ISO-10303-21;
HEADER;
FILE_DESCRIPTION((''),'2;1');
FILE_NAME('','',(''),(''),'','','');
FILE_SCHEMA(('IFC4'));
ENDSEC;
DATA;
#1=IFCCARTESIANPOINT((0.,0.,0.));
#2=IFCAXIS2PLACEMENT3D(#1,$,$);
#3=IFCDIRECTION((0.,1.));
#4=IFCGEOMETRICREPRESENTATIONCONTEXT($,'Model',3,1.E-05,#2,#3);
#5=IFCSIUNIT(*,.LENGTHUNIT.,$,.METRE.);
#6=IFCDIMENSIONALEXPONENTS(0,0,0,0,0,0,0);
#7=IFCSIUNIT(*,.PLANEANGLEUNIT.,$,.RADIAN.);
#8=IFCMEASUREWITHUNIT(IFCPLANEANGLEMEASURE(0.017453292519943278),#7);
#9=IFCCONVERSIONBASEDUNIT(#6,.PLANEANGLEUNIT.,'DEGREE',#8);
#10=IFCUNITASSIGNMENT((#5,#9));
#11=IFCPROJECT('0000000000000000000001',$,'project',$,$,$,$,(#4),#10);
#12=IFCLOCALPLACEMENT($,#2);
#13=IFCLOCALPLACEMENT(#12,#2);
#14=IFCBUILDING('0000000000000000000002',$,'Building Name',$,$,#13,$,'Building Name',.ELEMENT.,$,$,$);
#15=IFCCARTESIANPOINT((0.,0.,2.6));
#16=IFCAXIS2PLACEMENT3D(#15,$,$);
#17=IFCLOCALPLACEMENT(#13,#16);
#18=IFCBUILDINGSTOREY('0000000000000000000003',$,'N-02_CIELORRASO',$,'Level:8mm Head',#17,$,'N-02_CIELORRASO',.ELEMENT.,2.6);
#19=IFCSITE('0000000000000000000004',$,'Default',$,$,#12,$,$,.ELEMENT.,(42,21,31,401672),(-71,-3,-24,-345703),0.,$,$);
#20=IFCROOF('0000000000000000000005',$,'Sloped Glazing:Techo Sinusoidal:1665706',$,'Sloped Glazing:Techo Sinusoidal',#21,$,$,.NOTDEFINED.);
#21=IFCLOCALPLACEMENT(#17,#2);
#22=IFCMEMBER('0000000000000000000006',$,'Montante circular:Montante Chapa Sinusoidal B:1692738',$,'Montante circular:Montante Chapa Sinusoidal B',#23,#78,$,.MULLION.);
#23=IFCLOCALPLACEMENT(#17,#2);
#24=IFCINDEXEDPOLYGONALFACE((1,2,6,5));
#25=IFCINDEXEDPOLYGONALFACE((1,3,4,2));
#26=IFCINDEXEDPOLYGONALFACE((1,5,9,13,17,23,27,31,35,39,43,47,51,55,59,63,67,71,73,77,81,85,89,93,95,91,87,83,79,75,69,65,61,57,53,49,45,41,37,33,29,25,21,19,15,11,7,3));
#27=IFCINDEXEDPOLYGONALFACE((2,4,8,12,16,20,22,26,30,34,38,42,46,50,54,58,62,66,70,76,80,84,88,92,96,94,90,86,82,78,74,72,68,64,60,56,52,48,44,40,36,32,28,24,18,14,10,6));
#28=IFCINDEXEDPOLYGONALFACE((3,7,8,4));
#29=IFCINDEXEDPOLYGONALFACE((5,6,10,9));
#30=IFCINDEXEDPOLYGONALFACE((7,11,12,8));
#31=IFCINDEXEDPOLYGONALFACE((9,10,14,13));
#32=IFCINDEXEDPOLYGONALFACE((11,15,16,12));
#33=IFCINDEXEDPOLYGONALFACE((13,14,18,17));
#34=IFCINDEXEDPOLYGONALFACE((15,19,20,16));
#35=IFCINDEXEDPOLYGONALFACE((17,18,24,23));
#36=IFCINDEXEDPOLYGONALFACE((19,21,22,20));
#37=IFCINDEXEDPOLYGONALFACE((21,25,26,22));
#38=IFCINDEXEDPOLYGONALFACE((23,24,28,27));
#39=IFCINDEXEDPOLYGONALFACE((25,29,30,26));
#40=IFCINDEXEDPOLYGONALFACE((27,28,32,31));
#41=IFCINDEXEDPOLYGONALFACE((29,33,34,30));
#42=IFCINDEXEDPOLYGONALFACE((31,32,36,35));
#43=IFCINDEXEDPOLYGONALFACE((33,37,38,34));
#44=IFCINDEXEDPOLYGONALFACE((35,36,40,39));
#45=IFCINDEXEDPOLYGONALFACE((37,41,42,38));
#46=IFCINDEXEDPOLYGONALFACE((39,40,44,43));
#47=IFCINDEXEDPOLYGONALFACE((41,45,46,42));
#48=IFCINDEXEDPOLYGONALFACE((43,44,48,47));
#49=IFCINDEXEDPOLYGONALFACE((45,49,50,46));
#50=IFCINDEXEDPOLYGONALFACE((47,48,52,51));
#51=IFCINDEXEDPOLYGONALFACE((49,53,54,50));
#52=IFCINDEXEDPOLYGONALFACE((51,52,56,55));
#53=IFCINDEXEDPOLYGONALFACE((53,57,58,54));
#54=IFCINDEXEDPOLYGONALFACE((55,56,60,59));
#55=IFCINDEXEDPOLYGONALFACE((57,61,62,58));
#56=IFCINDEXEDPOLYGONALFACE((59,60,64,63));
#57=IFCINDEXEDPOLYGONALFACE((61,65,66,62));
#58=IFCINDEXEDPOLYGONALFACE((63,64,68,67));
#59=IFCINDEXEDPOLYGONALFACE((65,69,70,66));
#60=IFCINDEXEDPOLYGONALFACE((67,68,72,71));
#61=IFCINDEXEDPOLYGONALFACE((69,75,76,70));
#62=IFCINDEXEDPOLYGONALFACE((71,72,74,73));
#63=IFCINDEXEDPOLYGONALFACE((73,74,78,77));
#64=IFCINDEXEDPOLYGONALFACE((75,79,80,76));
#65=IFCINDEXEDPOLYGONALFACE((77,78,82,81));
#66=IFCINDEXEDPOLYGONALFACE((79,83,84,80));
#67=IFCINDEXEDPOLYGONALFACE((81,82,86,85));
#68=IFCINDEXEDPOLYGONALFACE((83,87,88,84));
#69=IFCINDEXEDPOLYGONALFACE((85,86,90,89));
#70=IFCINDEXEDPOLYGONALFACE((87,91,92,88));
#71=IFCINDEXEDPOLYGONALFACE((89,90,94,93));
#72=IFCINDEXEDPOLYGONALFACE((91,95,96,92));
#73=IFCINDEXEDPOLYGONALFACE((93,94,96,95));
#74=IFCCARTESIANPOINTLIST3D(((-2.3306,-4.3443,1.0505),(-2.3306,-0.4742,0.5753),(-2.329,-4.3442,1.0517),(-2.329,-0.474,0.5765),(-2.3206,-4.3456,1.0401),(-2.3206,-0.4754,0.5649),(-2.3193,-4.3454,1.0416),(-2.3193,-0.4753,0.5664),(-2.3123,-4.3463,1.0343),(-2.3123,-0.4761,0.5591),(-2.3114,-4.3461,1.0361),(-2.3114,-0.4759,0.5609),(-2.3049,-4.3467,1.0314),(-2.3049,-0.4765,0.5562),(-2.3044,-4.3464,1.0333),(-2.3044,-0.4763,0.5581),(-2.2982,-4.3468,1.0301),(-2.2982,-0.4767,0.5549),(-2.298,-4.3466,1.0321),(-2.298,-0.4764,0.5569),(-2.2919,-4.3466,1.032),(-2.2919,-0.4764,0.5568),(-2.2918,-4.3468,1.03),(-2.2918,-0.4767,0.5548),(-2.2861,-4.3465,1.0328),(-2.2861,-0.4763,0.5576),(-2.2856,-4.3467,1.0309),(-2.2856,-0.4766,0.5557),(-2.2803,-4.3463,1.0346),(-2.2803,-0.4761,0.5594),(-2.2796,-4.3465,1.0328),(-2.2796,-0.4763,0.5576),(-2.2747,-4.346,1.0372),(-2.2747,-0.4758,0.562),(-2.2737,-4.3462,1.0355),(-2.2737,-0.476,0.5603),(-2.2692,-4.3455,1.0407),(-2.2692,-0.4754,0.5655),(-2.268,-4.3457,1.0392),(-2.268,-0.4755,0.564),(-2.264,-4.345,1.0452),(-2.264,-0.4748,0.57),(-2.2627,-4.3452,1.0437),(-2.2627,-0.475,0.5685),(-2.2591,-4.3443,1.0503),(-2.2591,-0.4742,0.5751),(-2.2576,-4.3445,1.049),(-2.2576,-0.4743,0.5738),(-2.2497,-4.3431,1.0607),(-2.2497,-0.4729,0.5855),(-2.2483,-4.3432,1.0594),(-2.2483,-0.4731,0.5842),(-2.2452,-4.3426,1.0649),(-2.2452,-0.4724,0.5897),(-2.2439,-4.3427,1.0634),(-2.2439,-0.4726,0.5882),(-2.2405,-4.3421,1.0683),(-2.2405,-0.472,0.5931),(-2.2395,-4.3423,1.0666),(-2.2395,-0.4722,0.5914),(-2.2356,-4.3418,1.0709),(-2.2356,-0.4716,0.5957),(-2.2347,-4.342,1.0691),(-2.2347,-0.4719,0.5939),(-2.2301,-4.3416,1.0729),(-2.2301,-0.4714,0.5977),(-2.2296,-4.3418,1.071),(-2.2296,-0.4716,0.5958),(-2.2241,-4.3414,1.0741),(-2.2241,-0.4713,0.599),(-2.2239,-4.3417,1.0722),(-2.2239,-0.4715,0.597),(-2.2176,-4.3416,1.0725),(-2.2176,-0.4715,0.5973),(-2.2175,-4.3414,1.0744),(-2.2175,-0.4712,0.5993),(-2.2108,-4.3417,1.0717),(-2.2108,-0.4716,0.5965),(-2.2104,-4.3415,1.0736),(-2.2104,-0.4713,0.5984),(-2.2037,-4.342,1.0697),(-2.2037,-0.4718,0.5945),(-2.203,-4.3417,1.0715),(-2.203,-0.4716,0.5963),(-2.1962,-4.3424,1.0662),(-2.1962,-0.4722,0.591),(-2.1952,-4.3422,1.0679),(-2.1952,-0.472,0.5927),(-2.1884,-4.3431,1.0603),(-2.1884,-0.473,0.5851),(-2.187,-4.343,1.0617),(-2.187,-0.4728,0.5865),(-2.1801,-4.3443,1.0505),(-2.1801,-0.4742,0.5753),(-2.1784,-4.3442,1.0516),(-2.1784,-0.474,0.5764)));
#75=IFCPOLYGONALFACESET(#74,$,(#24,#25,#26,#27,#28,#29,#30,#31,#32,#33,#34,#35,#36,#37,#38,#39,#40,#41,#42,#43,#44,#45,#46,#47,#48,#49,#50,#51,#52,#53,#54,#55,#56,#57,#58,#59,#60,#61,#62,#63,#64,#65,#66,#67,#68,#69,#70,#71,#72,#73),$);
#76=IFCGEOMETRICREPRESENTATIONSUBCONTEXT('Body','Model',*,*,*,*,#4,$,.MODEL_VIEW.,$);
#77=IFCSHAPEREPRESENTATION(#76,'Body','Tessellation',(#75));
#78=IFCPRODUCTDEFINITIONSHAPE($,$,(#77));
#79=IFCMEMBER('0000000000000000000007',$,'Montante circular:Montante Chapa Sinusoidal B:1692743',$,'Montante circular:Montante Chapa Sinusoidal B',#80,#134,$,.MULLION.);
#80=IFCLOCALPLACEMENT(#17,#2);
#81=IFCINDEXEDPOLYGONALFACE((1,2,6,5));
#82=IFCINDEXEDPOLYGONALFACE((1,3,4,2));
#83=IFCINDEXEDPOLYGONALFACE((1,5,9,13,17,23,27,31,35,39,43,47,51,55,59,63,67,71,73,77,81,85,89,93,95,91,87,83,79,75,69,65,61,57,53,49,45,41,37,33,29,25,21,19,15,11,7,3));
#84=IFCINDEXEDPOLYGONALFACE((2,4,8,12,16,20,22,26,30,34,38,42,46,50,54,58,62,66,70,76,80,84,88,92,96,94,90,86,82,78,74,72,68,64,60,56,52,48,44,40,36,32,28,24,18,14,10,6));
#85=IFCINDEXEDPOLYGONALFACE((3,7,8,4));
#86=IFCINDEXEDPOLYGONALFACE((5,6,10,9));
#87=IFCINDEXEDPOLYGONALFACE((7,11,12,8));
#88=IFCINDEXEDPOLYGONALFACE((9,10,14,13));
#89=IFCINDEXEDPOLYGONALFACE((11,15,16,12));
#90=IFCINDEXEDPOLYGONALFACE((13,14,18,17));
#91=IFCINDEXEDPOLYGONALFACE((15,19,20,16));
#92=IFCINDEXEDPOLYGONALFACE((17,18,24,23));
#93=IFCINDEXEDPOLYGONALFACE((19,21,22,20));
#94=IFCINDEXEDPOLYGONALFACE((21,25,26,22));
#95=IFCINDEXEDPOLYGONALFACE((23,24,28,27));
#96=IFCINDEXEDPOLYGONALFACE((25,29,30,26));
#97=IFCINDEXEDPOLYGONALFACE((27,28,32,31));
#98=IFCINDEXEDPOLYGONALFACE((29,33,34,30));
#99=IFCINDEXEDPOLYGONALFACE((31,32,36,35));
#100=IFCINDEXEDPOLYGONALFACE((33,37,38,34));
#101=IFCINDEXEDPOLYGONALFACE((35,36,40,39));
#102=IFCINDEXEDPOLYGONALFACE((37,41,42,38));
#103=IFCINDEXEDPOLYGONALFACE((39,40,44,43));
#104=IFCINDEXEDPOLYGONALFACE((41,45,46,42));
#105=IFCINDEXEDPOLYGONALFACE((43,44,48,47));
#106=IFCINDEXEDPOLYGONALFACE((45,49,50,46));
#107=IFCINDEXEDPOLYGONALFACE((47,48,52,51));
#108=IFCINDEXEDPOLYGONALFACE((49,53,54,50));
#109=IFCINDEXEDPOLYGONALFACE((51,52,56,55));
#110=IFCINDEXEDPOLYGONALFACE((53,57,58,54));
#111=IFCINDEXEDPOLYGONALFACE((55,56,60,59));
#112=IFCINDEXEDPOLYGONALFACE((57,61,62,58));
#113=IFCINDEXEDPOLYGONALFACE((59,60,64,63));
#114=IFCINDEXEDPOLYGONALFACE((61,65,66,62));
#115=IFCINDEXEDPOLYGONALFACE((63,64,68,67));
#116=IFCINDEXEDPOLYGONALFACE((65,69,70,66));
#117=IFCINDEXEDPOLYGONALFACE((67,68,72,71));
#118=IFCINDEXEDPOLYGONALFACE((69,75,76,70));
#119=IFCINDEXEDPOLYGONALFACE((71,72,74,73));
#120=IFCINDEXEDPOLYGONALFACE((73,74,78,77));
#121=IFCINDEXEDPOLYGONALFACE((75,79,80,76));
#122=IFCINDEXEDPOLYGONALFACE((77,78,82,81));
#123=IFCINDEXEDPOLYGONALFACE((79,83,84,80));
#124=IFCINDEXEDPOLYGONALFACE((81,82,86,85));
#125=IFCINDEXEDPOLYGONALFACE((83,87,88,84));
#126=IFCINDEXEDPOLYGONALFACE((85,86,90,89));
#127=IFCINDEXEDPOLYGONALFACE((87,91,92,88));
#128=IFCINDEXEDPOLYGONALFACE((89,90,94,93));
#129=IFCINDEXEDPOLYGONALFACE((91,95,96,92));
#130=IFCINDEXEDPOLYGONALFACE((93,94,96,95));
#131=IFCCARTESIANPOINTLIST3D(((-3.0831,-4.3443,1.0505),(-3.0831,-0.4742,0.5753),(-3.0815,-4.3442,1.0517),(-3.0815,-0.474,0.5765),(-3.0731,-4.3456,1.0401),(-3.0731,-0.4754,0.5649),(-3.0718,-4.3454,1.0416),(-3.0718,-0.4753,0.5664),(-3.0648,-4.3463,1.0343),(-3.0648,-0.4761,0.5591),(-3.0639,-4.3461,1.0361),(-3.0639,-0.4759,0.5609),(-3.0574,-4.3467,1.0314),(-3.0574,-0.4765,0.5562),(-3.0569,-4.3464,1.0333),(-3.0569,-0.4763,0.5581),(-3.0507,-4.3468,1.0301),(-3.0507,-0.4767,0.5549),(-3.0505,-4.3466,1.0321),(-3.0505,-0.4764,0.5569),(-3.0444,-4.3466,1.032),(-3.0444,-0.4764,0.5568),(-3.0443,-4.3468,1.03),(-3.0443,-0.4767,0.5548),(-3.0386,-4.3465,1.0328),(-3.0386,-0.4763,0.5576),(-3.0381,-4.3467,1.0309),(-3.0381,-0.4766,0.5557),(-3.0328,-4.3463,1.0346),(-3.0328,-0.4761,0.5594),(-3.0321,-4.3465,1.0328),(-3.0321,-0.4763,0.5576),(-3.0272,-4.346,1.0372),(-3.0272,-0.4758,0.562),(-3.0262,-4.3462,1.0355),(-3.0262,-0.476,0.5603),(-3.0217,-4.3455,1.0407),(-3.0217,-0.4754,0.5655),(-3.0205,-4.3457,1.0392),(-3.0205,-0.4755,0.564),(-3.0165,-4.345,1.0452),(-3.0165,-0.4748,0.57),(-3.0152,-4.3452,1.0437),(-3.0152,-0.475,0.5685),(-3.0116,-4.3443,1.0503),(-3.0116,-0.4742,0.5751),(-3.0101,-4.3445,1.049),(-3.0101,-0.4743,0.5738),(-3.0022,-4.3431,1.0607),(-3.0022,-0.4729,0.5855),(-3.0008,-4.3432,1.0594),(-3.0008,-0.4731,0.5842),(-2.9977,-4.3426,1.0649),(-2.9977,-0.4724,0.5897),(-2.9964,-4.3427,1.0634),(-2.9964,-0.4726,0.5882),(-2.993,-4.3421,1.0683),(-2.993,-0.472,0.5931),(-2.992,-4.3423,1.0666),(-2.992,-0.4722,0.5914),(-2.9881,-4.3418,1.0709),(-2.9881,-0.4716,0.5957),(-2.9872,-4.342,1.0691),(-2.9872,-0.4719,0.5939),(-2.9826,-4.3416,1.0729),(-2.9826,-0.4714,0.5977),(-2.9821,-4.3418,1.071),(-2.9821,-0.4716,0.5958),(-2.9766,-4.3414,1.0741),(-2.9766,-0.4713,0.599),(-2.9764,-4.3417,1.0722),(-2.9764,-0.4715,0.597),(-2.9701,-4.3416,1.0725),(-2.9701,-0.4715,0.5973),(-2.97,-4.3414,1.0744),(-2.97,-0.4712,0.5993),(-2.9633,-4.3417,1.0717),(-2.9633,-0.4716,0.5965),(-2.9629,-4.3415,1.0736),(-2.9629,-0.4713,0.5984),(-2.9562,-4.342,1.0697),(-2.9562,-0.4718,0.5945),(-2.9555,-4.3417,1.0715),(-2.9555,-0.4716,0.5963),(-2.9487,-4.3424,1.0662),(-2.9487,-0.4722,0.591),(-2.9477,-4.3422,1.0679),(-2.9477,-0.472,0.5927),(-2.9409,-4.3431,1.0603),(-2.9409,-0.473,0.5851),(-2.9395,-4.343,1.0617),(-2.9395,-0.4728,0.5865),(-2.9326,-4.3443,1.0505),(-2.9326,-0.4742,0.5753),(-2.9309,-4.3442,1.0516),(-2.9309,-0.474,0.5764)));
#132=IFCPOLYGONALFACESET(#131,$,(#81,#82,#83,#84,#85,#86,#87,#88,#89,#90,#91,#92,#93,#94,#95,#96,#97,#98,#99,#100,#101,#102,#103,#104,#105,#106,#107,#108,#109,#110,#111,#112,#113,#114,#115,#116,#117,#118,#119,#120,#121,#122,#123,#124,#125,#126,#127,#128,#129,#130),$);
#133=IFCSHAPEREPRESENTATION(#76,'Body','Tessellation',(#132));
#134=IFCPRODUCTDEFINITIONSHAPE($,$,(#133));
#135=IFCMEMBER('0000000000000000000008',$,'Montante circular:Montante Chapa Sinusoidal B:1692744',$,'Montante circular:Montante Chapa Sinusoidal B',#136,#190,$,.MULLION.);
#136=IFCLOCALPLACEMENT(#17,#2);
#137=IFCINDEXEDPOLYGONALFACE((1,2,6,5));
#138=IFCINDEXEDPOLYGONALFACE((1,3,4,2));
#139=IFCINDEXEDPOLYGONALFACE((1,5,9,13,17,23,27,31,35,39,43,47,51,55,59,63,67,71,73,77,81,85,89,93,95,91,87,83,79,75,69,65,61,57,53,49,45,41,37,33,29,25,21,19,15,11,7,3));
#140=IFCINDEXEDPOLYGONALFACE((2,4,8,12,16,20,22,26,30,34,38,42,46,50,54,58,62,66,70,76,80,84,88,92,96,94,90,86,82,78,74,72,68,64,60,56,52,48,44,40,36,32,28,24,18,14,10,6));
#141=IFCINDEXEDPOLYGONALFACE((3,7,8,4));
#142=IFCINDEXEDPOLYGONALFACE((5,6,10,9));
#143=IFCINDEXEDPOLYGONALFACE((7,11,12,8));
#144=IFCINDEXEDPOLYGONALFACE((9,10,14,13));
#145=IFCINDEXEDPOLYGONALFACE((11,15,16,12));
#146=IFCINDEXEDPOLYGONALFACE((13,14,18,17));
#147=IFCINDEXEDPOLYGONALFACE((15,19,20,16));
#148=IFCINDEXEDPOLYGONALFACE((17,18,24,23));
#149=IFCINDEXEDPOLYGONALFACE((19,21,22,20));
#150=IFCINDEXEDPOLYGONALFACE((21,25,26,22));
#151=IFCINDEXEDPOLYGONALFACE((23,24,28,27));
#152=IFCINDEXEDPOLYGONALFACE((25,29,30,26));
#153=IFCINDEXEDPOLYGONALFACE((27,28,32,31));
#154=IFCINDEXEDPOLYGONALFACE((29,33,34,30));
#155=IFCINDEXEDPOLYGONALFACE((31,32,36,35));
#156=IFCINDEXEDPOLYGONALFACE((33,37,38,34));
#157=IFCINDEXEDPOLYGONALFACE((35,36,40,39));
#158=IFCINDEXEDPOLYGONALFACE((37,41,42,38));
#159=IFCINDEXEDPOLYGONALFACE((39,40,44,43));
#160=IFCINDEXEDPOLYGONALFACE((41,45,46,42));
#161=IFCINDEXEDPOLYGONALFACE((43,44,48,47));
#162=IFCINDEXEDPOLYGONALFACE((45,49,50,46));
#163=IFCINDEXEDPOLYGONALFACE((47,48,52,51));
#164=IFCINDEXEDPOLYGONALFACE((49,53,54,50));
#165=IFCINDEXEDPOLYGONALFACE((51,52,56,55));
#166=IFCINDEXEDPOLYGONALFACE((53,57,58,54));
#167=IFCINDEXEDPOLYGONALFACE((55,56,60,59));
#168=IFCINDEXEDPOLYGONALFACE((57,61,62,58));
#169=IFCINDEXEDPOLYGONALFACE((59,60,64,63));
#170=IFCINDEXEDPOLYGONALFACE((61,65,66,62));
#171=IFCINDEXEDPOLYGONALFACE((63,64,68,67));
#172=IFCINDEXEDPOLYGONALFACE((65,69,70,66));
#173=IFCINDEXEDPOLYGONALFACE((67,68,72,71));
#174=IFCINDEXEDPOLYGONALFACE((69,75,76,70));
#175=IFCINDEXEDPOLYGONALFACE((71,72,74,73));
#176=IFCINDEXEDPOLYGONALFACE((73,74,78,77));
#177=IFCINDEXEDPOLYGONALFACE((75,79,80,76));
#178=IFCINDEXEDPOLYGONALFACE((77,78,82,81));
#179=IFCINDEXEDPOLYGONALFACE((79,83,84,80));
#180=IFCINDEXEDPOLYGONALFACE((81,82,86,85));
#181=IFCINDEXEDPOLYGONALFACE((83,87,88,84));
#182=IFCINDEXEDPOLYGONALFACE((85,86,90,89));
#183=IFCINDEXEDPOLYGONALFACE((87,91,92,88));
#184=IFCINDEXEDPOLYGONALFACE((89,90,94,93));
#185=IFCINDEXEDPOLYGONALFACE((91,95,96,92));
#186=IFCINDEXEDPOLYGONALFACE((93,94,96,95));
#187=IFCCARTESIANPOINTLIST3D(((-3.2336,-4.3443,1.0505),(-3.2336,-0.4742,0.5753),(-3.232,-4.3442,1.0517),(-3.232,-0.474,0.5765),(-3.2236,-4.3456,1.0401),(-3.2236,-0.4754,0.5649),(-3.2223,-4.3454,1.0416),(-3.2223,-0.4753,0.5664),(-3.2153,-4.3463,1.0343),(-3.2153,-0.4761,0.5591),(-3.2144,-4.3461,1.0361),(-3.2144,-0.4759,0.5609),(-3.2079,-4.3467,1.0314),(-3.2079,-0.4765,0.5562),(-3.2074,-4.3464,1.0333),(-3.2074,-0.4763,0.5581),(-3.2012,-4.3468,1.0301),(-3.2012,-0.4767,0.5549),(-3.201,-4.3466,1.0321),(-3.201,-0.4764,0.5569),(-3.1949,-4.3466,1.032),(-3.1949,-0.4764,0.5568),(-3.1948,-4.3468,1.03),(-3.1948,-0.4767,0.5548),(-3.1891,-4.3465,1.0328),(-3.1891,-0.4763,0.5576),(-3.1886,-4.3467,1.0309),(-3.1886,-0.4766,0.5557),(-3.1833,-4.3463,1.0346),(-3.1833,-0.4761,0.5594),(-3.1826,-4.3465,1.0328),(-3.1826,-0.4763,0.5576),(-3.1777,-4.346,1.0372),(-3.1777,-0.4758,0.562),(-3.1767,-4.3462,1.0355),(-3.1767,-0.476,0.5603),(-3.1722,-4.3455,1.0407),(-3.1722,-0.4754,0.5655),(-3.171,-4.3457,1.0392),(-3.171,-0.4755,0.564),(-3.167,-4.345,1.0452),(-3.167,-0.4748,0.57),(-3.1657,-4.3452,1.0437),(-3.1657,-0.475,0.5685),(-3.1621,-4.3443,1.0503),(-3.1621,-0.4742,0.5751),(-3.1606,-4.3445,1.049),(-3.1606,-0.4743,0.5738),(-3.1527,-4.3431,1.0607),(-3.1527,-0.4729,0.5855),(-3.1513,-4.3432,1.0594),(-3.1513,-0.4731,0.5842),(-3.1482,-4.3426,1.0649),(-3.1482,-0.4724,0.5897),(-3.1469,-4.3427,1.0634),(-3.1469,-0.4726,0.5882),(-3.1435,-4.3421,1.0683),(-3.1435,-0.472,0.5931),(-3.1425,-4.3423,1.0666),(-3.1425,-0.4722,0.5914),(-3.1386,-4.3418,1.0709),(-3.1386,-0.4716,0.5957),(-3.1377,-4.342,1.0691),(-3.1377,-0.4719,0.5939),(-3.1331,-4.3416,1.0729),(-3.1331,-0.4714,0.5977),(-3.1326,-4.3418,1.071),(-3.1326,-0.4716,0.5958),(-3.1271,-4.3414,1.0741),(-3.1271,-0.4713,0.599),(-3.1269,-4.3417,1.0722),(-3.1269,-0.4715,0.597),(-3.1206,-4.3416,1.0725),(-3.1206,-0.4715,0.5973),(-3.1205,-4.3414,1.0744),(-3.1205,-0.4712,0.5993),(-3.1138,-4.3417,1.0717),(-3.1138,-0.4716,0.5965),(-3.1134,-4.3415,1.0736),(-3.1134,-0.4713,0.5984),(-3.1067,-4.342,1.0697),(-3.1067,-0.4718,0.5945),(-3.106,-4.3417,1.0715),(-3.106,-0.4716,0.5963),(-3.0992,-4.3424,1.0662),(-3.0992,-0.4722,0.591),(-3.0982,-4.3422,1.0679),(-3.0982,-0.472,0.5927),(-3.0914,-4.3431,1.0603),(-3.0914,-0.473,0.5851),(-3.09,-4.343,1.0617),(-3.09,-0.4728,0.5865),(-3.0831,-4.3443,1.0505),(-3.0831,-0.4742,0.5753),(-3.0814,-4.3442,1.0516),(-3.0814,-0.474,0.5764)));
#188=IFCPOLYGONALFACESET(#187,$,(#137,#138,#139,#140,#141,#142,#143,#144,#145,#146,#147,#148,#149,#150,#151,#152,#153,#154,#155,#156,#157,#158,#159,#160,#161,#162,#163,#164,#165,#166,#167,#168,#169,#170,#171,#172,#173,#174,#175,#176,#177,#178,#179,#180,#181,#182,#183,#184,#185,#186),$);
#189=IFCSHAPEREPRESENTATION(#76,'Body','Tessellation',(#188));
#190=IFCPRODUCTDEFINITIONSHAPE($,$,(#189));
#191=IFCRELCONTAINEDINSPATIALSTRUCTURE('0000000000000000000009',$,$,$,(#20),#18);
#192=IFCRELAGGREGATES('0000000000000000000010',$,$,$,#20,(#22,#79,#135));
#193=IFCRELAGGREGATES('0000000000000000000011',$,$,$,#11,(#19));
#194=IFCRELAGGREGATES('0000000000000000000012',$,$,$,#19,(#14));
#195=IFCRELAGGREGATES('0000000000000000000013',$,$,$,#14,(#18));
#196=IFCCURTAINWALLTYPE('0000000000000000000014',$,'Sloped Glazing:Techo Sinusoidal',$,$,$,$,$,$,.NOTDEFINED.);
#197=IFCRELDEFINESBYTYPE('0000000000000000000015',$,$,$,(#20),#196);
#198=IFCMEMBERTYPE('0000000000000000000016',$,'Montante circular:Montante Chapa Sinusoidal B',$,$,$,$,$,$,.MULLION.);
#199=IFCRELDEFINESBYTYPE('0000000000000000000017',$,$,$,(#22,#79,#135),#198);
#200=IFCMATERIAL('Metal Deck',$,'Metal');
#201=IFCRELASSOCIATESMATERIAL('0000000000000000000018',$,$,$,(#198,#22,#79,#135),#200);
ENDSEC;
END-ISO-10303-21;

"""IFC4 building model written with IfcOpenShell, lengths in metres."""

from ifc_helpers import new_model, entity, si_unit, converted_unit, direction, frame, origin, place, context, subcontext, project, spatial, indexed_curve, outline, extrude, source, transform, mapped, material, type_object, type_shapes, element, aggregate, save


model = new_model("IFC4")

# Units and contexts
model_context = context("Model", 3, precision=1e-05, world=origin(), true_north=direction((0.0, 1.0)))
body_context = subcontext(model_context, "Body", "Model", "MODEL_VIEW")
ifc_project = project(units=[si_unit("LENGTHUNIT", "METRE"), converted_unit("PLANEANGLEUNIT", "DEGREE", entity("IfcPlaneAngleMeasure", 0.017453292519943278), si_unit("PLANEANGLEUNIT", "RADIAN"), dimensions=[0, 0, 0, 0, 0, 0, 0])], contexts=[model_context])

# Site, building, storey
site_placement = place(None, origin())
site = spatial("IfcSite", under=ifc_project, at=site_placement, Name="Default", CompositionType="ELEMENT", RefLatitude=(42, 21, 31, 401672), RefLongitude=(-71, -3, -24, -345703), RefElevation=0.0)
building_placement = place(site_placement, origin())
building = spatial("IfcBuilding", under=site, at=building_placement, Name="Building Name", LongName="Building Name", CompositionType="ELEMENT")
storey_placement = place(building_placement, frame((0.0, 0.0, 2.6)))
storey = spatial("IfcBuildingStorey", under=building, at=storey_placement, Name="N-02_CIELORRASO", ObjectType="Level:8mm Head", LongName="N-02_CIELORRASO", CompositionType="ELEMENT", Elevation=2.6)

# Roof, members
curtain_wall_type = type_object("IfcCurtainWallType", Name="Sloped Glazing:Techo Sinusoidal", PredefinedType="NOTDEFINED")
ifc_material = material(Name="Metal Deck", Category="Metal")
roof_1_placement = place(storey_placement, frame((0.0, 0.0, -2.6)))
roof_1 = element("IfcRoof", 1, at=roof_1_placement, inside=storey, type_object=curtain_wall_type, Name="Sloped Glazing:Techo Sinusoidal:1665706", ObjectType="Sloped Glazing:Techo Sinusoidal", PredefinedType="NOTDEFINED")
member_type_1 = type_object("IfcMemberType", Name="Montante circular:Montante Chapa Sinusoidal B", PredefinedType="MULLION", material=ifc_material)
shared_shape_1 = source(origin(), body_context, "Body", "SweptSolid", [
    extrude(outline(indexed_curve([(0.0595, -0.0443), (0.0615, -0.0443), (0.0603, -0.031), (0.0572, -0.0213), (0.053, -0.0138), (0.0481, -0.0078), (0.0427, -0.003), (0.0372, 0.0005), (0.0315, 0.0029), (0.0259, 0.0044), (0.0203, 0.0051), (0.0146, 0.005), (0.0084, 0.0041), (-0.0053, 0.0009), (-0.0123, -0.0005), (-0.0191, -0.0012), (-0.0256, -0.001), (-0.0317, 0.0001), (-0.0375, 0.0019), (-0.0428, 0.0046), (-0.0477, 0.0081), (-0.0522, 0.0128), (-0.0563, 0.0191), (-0.0597, 0.0282), (-0.0617, 0.0421), (-0.0637, 0.042), (-0.0616, 0.0277), (-0.0581, 0.0182), (-0.0537, 0.0116), (-0.049, 0.0066), (-0.0438, 0.0028), (-0.0382, 0.0001), (-0.0322, -0.0019), (-0.0258, -0.003), (-0.019, -0.0032), (-0.012, -0.0025), (-0.0048, -0.0011), (0.0088, 0.0021), (0.0147, 0.003), (0.0202, 0.0031), (0.0255, 0.0024), (0.0309, 0.001), (0.0362, -0.0013), (0.0415, -0.0046), (0.0466, -0.0092), (0.0513, -0.0149), (0.0554, -0.0221), (0.0584, -0.0314), (0.0595, -0.0443)], self_intersect=False)), frame((-0.007, 0.0228, -3.8992), z_axis=(0.0, 0.0, 1.0), x_axis=(-0.819152, -0.573576, 0.0)), (0.0, 0.0, 1.0), 3.8992),
])
type_shapes(member_type_1, [shared_shape_1])
member_1_placement = place(roof_1_placement, frame((-2.2613, -4.3413, 3.6752), z_axis=(0.0, -0.992546, 0.121869), x_axis=(-1.0, 0.0, 0.0)))
member_1 = element("IfcMember", 2, at=member_1_placement, type_object=member_type_1, material=ifc_material, Name="Montante circular:Montante Chapa Sinusoidal B:1692738", ObjectType="Montante circular:Montante Chapa Sinusoidal B", PredefinedType="MULLION", context=body_context, shape_type="MappedRepresentation", body=[
    mapped(shared_shape_1, transform((0.0, 0.0, 0.0), scale=1.0)),
])
member_2_placement = place(roof_1_placement, frame((-3.0138, -4.3413, 3.6752), z_axis=(0.0, -0.992546, 0.121869), x_axis=(-1.0, 0.0, 0.0)))
member_2 = element("IfcMember", 3, at=member_2_placement, type_object=member_type_1, material=ifc_material, Name="Montante circular:Montante Chapa Sinusoidal B:1692743", ObjectType="Montante circular:Montante Chapa Sinusoidal B", PredefinedType="MULLION", context=body_context, shape_type="MappedRepresentation", body=[
    mapped(shared_shape_1, transform((0.0, 0.0, 0.0), scale=1.0)),
])
member_3_placement = place(roof_1_placement, frame((-3.1643, -4.3413, 3.6752), z_axis=(0.0, -0.992546, 0.121869), x_axis=(-1.0, 0.0, 0.0)))
member_3 = element("IfcMember", 4, at=member_3_placement, type_object=member_type_1, material=ifc_material, Name="Montante circular:Montante Chapa Sinusoidal B:1692744", ObjectType="Montante circular:Montante Chapa Sinusoidal B", PredefinedType="MULLION", context=body_context, shape_type="MappedRepresentation", body=[
    mapped(shared_shape_1, transform((0.0, 0.0, 0.0), scale=1.0)),
])
aggregate(roof_1, [member_1, member_2, member_3])

save(model, "model.ifc")
